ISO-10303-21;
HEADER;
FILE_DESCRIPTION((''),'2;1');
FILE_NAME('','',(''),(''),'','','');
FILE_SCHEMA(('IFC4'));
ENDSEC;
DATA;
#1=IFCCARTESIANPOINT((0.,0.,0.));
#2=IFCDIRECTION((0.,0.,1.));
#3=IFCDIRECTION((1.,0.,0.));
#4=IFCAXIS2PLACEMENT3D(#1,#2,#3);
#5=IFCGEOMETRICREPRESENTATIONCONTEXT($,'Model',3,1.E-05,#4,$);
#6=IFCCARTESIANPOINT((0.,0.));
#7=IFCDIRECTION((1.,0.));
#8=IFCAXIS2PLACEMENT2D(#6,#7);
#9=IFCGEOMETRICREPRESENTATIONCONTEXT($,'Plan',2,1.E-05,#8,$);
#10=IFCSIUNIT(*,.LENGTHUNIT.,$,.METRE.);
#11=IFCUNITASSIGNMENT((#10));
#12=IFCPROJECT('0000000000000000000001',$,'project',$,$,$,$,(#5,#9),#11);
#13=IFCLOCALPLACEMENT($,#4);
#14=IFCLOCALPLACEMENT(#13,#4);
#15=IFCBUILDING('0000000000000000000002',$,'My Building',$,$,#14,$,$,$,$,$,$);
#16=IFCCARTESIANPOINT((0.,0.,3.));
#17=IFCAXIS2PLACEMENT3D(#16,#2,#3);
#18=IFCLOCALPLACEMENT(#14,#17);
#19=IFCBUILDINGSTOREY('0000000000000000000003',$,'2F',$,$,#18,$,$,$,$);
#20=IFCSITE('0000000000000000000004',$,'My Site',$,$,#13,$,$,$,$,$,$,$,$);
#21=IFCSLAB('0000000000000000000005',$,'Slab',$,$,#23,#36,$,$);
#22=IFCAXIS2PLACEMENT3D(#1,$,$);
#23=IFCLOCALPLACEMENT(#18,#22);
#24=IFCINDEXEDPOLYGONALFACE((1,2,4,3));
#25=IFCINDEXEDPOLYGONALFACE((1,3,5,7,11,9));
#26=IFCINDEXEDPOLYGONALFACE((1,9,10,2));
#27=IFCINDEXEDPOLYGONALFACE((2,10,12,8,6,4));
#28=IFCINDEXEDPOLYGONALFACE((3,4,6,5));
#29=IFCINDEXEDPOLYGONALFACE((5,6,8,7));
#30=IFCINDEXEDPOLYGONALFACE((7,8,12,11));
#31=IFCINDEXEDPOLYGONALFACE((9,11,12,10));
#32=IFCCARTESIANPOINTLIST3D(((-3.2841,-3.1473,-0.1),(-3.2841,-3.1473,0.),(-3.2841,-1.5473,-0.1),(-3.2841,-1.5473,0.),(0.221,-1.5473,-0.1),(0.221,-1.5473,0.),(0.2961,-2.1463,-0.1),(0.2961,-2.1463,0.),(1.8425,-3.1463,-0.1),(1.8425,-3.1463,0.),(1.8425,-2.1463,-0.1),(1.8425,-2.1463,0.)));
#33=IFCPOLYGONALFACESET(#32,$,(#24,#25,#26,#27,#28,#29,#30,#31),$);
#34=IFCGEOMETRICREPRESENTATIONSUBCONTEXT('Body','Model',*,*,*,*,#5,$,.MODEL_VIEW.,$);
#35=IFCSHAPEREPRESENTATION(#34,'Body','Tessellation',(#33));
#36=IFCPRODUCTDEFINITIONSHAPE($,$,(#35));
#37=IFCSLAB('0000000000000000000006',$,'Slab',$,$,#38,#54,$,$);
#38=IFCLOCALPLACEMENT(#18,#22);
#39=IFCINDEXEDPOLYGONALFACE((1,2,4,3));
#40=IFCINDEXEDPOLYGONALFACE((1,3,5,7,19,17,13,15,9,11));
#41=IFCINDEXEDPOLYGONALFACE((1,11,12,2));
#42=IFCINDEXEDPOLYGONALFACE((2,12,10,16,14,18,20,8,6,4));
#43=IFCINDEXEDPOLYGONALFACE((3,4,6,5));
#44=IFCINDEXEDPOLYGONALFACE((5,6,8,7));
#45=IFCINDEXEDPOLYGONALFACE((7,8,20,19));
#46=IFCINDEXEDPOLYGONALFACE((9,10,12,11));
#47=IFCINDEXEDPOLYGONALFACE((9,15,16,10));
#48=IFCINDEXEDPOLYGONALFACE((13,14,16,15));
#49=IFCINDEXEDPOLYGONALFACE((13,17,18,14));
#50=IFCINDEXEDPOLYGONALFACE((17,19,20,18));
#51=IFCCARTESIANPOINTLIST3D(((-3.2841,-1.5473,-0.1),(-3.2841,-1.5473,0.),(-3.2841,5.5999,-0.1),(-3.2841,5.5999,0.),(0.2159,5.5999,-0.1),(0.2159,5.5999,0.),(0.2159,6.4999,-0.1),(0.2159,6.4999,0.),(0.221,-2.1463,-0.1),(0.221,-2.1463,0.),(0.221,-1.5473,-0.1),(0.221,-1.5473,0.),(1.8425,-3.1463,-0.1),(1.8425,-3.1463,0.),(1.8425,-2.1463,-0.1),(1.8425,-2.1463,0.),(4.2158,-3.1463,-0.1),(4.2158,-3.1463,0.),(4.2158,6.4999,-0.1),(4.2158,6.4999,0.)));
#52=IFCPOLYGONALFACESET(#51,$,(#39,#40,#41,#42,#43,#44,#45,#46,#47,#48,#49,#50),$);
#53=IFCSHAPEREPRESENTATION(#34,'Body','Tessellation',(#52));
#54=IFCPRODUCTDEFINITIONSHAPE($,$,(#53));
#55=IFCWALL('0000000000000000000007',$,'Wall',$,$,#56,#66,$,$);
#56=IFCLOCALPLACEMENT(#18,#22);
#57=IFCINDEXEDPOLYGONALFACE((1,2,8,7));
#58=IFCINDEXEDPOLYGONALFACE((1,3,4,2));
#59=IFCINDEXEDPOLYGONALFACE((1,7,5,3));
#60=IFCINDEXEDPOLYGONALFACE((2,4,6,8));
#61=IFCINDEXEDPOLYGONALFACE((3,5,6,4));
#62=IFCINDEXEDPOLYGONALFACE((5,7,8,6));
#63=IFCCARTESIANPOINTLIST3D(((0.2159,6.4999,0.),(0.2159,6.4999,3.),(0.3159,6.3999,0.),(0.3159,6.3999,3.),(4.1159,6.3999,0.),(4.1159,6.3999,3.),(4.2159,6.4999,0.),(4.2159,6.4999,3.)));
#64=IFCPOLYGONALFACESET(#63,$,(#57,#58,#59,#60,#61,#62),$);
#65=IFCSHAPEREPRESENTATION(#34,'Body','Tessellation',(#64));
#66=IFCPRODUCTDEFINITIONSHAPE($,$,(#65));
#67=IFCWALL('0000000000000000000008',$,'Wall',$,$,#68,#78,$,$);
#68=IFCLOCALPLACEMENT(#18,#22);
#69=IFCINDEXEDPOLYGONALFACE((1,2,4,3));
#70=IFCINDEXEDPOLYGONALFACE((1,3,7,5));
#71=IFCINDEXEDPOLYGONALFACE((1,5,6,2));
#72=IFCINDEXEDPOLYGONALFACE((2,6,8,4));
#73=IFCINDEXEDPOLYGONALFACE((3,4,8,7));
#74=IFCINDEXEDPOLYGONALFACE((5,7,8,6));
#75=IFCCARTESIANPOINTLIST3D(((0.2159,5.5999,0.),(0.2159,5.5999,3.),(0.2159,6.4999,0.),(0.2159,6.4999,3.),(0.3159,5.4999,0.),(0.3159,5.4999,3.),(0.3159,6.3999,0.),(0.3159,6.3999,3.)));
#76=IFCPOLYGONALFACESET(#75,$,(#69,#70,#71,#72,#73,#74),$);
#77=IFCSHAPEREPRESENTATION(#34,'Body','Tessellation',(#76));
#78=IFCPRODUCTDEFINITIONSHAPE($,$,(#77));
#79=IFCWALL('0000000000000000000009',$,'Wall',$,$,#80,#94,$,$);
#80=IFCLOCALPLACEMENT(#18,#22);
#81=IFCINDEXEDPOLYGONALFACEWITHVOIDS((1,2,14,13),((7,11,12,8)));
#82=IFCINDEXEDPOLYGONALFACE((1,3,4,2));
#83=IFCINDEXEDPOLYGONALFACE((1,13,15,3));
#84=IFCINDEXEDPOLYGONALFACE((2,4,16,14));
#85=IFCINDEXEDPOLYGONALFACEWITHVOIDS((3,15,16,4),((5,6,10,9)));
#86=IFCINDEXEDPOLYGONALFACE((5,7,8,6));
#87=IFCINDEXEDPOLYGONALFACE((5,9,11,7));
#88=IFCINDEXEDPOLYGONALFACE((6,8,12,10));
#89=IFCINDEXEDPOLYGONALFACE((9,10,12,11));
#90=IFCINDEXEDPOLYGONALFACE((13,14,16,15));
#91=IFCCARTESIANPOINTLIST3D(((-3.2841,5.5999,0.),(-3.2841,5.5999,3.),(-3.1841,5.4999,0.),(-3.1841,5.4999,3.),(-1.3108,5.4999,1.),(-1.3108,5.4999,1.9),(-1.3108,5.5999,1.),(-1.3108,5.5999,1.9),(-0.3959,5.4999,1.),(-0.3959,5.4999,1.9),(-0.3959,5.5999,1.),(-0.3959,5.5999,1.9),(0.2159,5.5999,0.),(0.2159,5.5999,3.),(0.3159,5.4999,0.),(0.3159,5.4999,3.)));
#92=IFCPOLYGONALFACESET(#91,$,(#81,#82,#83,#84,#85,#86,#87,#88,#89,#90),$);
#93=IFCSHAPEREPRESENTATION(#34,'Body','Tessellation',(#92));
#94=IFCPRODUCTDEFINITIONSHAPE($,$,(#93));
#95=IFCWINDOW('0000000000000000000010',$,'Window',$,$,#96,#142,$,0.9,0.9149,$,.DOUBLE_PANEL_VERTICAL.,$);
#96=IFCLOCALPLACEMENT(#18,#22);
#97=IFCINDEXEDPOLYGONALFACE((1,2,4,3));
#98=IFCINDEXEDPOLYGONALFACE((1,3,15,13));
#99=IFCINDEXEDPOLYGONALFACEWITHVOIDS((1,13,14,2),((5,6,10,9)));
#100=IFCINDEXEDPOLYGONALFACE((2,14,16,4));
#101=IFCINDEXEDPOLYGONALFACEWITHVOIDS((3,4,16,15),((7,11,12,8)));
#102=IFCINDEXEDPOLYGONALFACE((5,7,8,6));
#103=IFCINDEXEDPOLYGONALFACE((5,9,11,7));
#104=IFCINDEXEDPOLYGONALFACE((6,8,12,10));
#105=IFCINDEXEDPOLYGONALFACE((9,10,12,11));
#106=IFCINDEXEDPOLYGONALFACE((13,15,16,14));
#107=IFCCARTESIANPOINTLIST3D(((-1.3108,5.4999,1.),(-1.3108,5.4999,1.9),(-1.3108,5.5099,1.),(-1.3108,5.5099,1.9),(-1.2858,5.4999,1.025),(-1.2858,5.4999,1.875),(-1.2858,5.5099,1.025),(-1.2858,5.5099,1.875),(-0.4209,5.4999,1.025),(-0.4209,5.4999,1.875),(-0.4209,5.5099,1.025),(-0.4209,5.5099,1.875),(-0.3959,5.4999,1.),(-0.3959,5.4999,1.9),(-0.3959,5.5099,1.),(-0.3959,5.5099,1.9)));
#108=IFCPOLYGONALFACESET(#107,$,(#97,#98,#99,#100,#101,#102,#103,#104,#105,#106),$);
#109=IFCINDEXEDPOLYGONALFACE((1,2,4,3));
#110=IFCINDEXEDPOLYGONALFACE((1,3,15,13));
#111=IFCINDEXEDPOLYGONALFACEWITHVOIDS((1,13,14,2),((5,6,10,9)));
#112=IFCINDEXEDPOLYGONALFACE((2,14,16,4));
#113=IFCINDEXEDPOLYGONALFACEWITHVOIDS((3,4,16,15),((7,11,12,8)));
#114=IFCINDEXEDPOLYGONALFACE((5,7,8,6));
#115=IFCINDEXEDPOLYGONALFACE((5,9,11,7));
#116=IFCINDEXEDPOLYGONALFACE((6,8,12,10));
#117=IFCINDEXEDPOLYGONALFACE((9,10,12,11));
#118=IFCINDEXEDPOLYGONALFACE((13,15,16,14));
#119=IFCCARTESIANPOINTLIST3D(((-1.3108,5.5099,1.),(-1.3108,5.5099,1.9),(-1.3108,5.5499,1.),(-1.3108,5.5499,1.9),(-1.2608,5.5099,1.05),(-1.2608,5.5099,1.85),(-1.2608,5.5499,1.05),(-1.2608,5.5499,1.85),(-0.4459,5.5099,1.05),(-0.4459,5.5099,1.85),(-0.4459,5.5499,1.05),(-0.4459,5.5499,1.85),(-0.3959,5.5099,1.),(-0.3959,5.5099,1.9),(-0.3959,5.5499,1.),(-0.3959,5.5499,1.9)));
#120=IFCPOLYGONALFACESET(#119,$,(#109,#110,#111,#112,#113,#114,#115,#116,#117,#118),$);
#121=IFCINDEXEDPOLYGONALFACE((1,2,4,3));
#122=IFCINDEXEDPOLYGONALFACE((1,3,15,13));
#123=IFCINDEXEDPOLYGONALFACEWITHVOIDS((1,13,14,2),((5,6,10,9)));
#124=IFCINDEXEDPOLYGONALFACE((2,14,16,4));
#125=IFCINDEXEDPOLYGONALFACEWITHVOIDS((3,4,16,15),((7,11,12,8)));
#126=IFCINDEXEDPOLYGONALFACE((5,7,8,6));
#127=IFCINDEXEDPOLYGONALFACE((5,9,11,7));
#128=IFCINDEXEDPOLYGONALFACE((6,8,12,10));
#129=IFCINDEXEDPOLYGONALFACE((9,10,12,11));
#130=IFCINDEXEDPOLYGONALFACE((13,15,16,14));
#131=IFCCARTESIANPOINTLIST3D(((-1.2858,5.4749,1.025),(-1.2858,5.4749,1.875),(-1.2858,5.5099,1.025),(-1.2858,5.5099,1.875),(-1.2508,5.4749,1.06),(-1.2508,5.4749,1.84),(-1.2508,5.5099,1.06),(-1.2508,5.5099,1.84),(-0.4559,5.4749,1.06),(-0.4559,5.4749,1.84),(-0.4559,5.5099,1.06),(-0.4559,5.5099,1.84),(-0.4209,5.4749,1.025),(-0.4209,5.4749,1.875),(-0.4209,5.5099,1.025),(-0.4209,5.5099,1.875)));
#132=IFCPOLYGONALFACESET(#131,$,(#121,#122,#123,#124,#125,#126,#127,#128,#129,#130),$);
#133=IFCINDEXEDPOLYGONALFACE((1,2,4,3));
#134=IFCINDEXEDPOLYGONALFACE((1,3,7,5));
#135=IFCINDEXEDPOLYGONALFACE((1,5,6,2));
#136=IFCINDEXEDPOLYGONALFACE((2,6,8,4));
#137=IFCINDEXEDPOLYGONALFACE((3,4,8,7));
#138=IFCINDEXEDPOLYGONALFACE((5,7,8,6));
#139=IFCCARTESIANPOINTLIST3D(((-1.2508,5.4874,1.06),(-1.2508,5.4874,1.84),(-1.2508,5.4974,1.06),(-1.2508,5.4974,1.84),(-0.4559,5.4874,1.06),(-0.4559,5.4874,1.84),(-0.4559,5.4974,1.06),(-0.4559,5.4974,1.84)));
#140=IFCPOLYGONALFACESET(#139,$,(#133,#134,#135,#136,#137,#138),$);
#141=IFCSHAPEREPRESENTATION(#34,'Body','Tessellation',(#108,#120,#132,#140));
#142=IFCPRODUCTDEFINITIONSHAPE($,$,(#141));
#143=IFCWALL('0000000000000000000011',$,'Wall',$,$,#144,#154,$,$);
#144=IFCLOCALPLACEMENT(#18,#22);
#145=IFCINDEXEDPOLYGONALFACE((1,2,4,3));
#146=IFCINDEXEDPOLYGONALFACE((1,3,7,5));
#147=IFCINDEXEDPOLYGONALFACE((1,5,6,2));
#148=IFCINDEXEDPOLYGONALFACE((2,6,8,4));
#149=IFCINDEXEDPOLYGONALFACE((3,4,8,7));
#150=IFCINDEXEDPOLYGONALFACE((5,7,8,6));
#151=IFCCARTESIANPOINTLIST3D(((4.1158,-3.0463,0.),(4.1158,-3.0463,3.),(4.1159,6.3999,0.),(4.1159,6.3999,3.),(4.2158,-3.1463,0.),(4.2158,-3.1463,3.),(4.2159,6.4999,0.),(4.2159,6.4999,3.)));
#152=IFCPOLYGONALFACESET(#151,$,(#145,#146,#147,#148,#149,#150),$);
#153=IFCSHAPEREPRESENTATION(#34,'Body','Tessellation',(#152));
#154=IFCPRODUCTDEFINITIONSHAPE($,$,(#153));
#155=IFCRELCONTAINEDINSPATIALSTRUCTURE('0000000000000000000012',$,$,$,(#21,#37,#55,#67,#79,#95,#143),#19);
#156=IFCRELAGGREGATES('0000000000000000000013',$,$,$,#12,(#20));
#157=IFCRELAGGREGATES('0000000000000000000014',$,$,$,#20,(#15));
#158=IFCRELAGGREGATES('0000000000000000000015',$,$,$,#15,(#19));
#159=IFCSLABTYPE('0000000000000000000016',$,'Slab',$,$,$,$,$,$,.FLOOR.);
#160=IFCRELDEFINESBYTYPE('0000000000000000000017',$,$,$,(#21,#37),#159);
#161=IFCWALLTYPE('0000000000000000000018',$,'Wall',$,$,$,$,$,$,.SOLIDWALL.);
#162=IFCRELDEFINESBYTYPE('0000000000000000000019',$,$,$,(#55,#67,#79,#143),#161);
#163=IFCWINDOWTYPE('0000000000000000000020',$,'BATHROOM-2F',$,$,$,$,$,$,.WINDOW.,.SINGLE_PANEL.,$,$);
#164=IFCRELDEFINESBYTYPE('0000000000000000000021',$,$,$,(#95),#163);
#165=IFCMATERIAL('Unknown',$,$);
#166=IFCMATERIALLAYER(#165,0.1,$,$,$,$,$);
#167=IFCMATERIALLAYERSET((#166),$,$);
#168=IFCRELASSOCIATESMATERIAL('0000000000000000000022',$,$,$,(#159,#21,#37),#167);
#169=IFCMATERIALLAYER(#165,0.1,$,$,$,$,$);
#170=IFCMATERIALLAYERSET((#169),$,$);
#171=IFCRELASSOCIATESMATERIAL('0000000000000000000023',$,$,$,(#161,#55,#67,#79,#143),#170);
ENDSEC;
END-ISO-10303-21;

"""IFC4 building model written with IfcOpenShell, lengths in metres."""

from ifc_helpers import new_model, entity, si_unit, frame, origin_with_axes, origin_2d_with_axis, place, context, subcontext, project, spatial, line, indexed_curve, outline, extrude, shape, source, transform, mapped, material, layer, layer_set, layer_usage, type_object, type_shapes, element, fill, save


model = new_model("IFC4")

# Units and contexts
model_context = context("Model", 3, precision=1e-05, world=origin_with_axes())
plan_context = context("Plan", 2, precision=1e-05, world=origin_2d_with_axis())
body_context_1 = subcontext(model_context, "Body", "Model", "MODEL_VIEW")
body_context_2 = subcontext(plan_context, "Body", "Plan", "PLAN_VIEW")
ifc_project = project(units=[si_unit("LENGTHUNIT", "METRE")], contexts=[model_context, plan_context])

# Site, building, storey
site_placement = place(None, origin_with_axes())
site = spatial("IfcSite", under=ifc_project, at=site_placement, Name="My Site")
building_placement = place(site_placement, origin_with_axes())
building = spatial("IfcBuilding", under=site, at=building_placement, Name="My Building")
storey_placement = place(building_placement, frame((0.0, 0.0, 3.0), z_axis=(0.0, 0.0, 1.0), x_axis=(1.0, 0.0, 0.0)))
storey = spatial("IfcBuildingStorey", under=building, at=storey_placement, Name="2F")

# Slabs
ifc_material_1 = material(Name="Unknown")
ifc_layer_1 = layer(ifc_material_1, 0.1)
ifc_layer_set_1 = layer_set([ifc_layer_1])
ifc_layer_usage_1 = layer_usage(ifc_layer_set_1, "AXIS3", "POSITIVE", -0.1)
slab_type = type_object("IfcSlabType", Name="Slab", PredefinedType="FLOOR", material=ifc_layer_set_1)
slab_1_placement = place(storey_placement, frame((-3.2841, -1.5473, 0.0), z_axis=(0.0, 0.0, 1.0), x_axis=(1.0, 0.0, 0.0)))
element("IfcSlab", 1, at=slab_1_placement, inside=storey, type_object=slab_type, material=ifc_layer_usage_1, Name="Slab", context=body_context_1, shape_type="SweptSolid", body=[
    extrude(outline(indexed_curve([(0.0, 0.0), (0.0, -1.6), (5.1266, -1.599), (5.1266, -0.599), (3.5803, -0.599), (3.5052, 0.0), (0.0, 0.0)])), frame((0.0, 0.0, -0.1), z_axis=(0.0, 0.0, 1.0), x_axis=(1.0, 0.0, 0.0)), (0.0, 0.0, 1.0), 0.1),
])
ifc_layer_usage_2 = layer_usage(ifc_layer_set_1, "AXIS3", "POSITIVE", -0.1)
slab_2_placement = place(storey_placement, frame((4.2158, 6.4999, 0.0), z_axis=(0.0, 0.0, 1.0), x_axis=(1.0, 0.0, 0.0)))
element("IfcSlab", 2, at=slab_2_placement, inside=storey, type_object=slab_type, material=ifc_layer_usage_2, Name="Slab", context=body_context_1, shape_type="SweptSolid", body=[
    extrude(outline(indexed_curve([(0.0, 0.0), (-4.0, 0.0), (-4.0, -0.9), (-7.5, -0.9), (-7.5, -8.0471), (-3.9948, -8.0471), (-3.9948, -8.6461), (-2.3734, -8.6461), (-2.3734, -9.6461), (0.0, -9.6461), (0.0, 0.0)])), frame((0.0, 0.0, -0.1), z_axis=(0.0, 0.0, 1.0), x_axis=(1.0, 0.0, 0.0)), (0.0, 0.0, 1.0), 0.1),
])

# Walls
ifc_layer_2 = layer(ifc_material_1, 0.1)
ifc_layer_set_2 = layer_set([ifc_layer_2])
ifc_layer_usage_3 = layer_usage(ifc_layer_set_2, "AXIS2", "POSITIVE", 0.0)
wall_type = type_object("IfcWallType", Name="Wall", PredefinedType="SOLIDWALL", material=ifc_layer_set_2)
wall_1_placement = place(storey_placement, frame((4.2159, 6.4999, 0.0), z_axis=(0.0, 0.0, 1.0), x_axis=(-1.0, 0.0, 0.0)))
element("IfcWall", 3, at=wall_1_placement, inside=storey, type_object=wall_type, material=ifc_layer_usage_3, Name="Wall", context=body_context_1, shape_type="SweptSolid", body=[
    extrude(outline(indexed_curve([(0.0, 0.0), (0.1, 0.1), (3.9, 0.1), (4.0, 0.0)], segments=[line(1, 2, 3, 4, 1)])), origin_with_axes(), (0.0, 0.0, 1.0), 3.0),
])
ifc_layer_usage_4 = layer_usage(ifc_layer_set_2, "AXIS2", "POSITIVE", 0.0)
wall_2_placement = place(storey_placement, frame((0.2159, 6.4999, 0.0), z_axis=(0.0, 0.0, 1.0), x_axis=(0.0, -1.0, 0.0)))
element("IfcWall", 4, at=wall_2_placement, inside=storey, type_object=wall_type, material=ifc_layer_usage_4, Name="Wall", context=body_context_1, shape_type="SweptSolid", body=[
    extrude(outline(indexed_curve([(0.0, 0.0), (0.1, 0.1), (1.0, 0.1), (0.9, 0.0)], segments=[line(1, 2, 3, 4, 1)])), origin_with_axes(), (0.0, 0.0, 1.0), 3.0),
])

# Wall, opening, window
ifc_layer_usage_5 = layer_usage(ifc_layer_set_2, "AXIS2", "POSITIVE", 0.0)
wall_3_placement = place(storey_placement, frame((0.2159, 5.5999, 0.0), z_axis=(0.0, 0.0, 1.0), x_axis=(-1.0, 0.0, 0.0)))
wall_3 = element("IfcWall", 5, at=wall_3_placement, inside=storey, type_object=wall_type, material=ifc_layer_usage_5, Name="Wall", context=body_context_1, shape_type="SweptSolid", body=[
    extrude(outline(indexed_curve([(0.0, 0.0), (-0.1, 0.1), (3.4, 0.1), (3.5, 0.0)], segments=[line(1, 2, 3, 4, 1)])), origin_with_axes(), (0.0, 0.0, 1.0), 3.0),
])
shared_shape_1 = source(origin_with_axes(), body_context_1, "Body", "SweptSolid", [
    extrude(outline(indexed_curve([(0.0, 0.0), (0.9149, 0.0), (0.9149, 0.9), (0.0, 0.9)], segments=[line(1, 2, 3, 4, 1)])), frame((0.0, -0.6, 0.0), z_axis=(0.0, -1.0, 0.0), x_axis=(1.0, 0.0, 0.0)), (0.0, 0.0, -1.0), 1.2),
])
opening_1_placement = place(wall_3_placement, frame((0.6117, 0.0, 1.0), z_axis=(0.0, 0.0, 1.0), x_axis=(1.0, -0.000001, 0.0)))
opening_1 = element("IfcOpeningElement", 6, at=opening_1_placement, cuts=wall_3, PredefinedType="OPENING", context=body_context_1, shape_type="MappedRepresentation", body=[
    mapped(shared_shape_1, transform((0.0, 0.0, 0.0), x_axis=(1.0, 0.0, 0.0), y_axis=(0.0, 1.0, 0.0), z_axis=(0.0, 0.0, 1.0), scale=1.0)),
])
window_type_1 = type_object("IfcWindowType", Name="BATHROOM-2F", PartitioningType="SINGLE_PANEL", PredefinedType="WINDOW")
shared_shape_2 = source(origin_with_axes(), body_context_1, "Body", "SweptSolid", [
    extrude(outline(indexed_curve([(0.0, 0.0), (0.9149, 0.0), (0.9149, 0.9), (0.0, 0.9)], segments=[line(1, 2, 3, 4, 1)]), holes=[indexed_curve([(0.025, 0.025), (0.8899, 0.025), (0.8899, 0.875), (0.025, 0.875)], segments=[line(1, 2, 3, 4, 1)])]), frame((0.0, 0.09, 0.0), z_axis=(0.0, -1.0, 0.0), x_axis=(1.0, 0.0, 0.0)), (0.0, 0.0, -1.0), 0.01),
    extrude(outline(indexed_curve([(0.0, 0.0), (0.9149, 0.0), (0.9149, 0.9), (0.0, 0.9)], segments=[line(1, 2, 3, 4, 1)]), holes=[indexed_curve([(0.05, 0.05), (0.8649, 0.05), (0.8649, 0.85), (0.05, 0.85)], segments=[line(1, 2, 3, 4, 1)])]), frame((0.0, 0.05, 0.0), z_axis=(0.0, -1.0, 0.0), x_axis=(1.0, 0.0, 0.0)), (0.0, 0.0, -1.0), 0.04),
    extrude(outline(indexed_curve([(0.0, 0.0), (0.8649, 0.0), (0.8649, 0.85), (0.0, 0.85)], segments=[line(1, 2, 3, 4, 1)]), holes=[indexed_curve([(0.035, 0.035), (0.8299, 0.035), (0.8299, 0.815), (0.035, 0.815)], segments=[line(1, 2, 3, 4, 1)])]), frame((0.025, 0.09, 0.025), z_axis=(0.0, -1.0, 0.0), x_axis=(1.0, 0.0, 0.0)), (0.0, 0.0, -1.0), 0.035),
    extrude(outline(indexed_curve([(0.035, 0.035), (0.8299, 0.035), (0.8299, 0.815), (0.035, 0.815)], segments=[line(1, 2, 3, 4, 1)])), frame((0.025, 0.1025, 0.025), z_axis=(0.0, -1.0, 0.0), x_axis=(1.0, 0.0, 0.0)), (0.0, 0.0, -1.0), 0.01),
])
shared_shape_3 = source(origin_with_axes(), body_context_2, "Body", "Curve2D", [
    entity("IfcIndexedPolyCurve", entity("IfcCartesianPointList2D", [[0.05, 0.05], [0.8649, 0.05]])),
    entity("IfcIndexedPolyCurve", entity("IfcCartesianPointList2D", [[0.0, 0.1], [0.025, 0.1], [0.025, 0.09], [0.05, 0.09], [0.05, 0.05], [0.0, 0.05]]), [entity("IfcLineIndex", [1, 2, 3, 4, 5, 6, 1])]),
    entity("IfcIndexedPolyCurve", entity("IfcCartesianPointList2D", [[0.9149, 0.1], [0.8899, 0.1], [0.8899, 0.09], [0.8649, 0.09], [0.8649, 0.05], [0.9149, 0.05]]), [entity("IfcLineIndex", [1, 2, 3, 4, 5, 6, 1])]),
    entity("IfcIndexedPolyCurve", entity("IfcCartesianPointList2D", [[0.025, 0.09], [0.06, 0.09], [0.06, 0.125], [0.025, 0.125]]), [entity("IfcLineIndex", [1, 2, 3, 4, 1])]),
    entity("IfcIndexedPolyCurve", entity("IfcCartesianPointList2D", [[0.8899, 0.09], [0.8549, 0.09], [0.8549, 0.125], [0.8899, 0.125]]), [entity("IfcLineIndex", [1, 2, 3, 4, 1])]),
    entity("IfcIndexedPolyCurve", entity("IfcCartesianPointList2D", [[0.06, 0.09], [0.8549, 0.09]])),
    entity("IfcIndexedPolyCurve", entity("IfcCartesianPointList2D", [[0.06, 0.125], [0.8549, 0.125]])),
    entity("IfcIndexedPolyCurve", entity("IfcCartesianPointList2D", [[0.06, 0.1075], [0.8549, 0.1075]])),
])
type_shapes(window_type_1, [shared_shape_2, shared_shape_3])
window_1_placement = place(opening_1_placement, frame((0.0, 0.0, 0.0), z_axis=(0.0, 0.0, 1.0), x_axis=(1.0, 0.0, 0.0)))
window_1 = element("IfcWindow", 7, at=window_1_placement, inside=storey, type_object=window_type_1, Name="Window", OverallHeight=0.9, OverallWidth=0.9149, PartitioningType="DOUBLE_PANEL_VERTICAL", shapes=[
    shape(body_context_1, "Body", "MappedRepresentation", [mapped(shared_shape_2, transform((0.0, 0.0, 0.0), x_axis=(1.0, 0.0, 0.0), y_axis=(0.0, 1.0, 0.0), z_axis=(0.0, 0.0, 1.0), scale=1.0))]),
    shape(body_context_2, "Body", "MappedRepresentation", [mapped(shared_shape_3, transform((0.0, 0.0, 0.0), x_axis=(1.0, 0.0, 0.0), y_axis=(0.0, 1.0, 0.0), z_axis=(0.0, 0.0, 1.0), scale=1.0))]),
])
fill(opening_1, window_1)

# Wall
ifc_layer_usage_6 = layer_usage(ifc_layer_set_2, "AXIS2", "POSITIVE", 0.0)
wall_4_placement = place(storey_placement, frame((4.2158, -3.1463, 0.0), z_axis=(0.0, 0.0, 1.0), x_axis=(0.0, 1.0, 0.0)))
element("IfcWall", 8, at=wall_4_placement, inside=storey, type_object=wall_type, material=ifc_layer_usage_6, Name="Wall", context=body_context_1, shape_type="SweptSolid", body=[
    extrude(outline(indexed_curve([(0.0, 0.0), (0.1, 0.1), (9.5461, 0.1), (9.6461, 0.0)], segments=[line(1, 2, 3, 4, 1)])), origin_with_axes(), (0.0, 0.0, 1.0), 3.0),
])

save(model, "model.ifc")
